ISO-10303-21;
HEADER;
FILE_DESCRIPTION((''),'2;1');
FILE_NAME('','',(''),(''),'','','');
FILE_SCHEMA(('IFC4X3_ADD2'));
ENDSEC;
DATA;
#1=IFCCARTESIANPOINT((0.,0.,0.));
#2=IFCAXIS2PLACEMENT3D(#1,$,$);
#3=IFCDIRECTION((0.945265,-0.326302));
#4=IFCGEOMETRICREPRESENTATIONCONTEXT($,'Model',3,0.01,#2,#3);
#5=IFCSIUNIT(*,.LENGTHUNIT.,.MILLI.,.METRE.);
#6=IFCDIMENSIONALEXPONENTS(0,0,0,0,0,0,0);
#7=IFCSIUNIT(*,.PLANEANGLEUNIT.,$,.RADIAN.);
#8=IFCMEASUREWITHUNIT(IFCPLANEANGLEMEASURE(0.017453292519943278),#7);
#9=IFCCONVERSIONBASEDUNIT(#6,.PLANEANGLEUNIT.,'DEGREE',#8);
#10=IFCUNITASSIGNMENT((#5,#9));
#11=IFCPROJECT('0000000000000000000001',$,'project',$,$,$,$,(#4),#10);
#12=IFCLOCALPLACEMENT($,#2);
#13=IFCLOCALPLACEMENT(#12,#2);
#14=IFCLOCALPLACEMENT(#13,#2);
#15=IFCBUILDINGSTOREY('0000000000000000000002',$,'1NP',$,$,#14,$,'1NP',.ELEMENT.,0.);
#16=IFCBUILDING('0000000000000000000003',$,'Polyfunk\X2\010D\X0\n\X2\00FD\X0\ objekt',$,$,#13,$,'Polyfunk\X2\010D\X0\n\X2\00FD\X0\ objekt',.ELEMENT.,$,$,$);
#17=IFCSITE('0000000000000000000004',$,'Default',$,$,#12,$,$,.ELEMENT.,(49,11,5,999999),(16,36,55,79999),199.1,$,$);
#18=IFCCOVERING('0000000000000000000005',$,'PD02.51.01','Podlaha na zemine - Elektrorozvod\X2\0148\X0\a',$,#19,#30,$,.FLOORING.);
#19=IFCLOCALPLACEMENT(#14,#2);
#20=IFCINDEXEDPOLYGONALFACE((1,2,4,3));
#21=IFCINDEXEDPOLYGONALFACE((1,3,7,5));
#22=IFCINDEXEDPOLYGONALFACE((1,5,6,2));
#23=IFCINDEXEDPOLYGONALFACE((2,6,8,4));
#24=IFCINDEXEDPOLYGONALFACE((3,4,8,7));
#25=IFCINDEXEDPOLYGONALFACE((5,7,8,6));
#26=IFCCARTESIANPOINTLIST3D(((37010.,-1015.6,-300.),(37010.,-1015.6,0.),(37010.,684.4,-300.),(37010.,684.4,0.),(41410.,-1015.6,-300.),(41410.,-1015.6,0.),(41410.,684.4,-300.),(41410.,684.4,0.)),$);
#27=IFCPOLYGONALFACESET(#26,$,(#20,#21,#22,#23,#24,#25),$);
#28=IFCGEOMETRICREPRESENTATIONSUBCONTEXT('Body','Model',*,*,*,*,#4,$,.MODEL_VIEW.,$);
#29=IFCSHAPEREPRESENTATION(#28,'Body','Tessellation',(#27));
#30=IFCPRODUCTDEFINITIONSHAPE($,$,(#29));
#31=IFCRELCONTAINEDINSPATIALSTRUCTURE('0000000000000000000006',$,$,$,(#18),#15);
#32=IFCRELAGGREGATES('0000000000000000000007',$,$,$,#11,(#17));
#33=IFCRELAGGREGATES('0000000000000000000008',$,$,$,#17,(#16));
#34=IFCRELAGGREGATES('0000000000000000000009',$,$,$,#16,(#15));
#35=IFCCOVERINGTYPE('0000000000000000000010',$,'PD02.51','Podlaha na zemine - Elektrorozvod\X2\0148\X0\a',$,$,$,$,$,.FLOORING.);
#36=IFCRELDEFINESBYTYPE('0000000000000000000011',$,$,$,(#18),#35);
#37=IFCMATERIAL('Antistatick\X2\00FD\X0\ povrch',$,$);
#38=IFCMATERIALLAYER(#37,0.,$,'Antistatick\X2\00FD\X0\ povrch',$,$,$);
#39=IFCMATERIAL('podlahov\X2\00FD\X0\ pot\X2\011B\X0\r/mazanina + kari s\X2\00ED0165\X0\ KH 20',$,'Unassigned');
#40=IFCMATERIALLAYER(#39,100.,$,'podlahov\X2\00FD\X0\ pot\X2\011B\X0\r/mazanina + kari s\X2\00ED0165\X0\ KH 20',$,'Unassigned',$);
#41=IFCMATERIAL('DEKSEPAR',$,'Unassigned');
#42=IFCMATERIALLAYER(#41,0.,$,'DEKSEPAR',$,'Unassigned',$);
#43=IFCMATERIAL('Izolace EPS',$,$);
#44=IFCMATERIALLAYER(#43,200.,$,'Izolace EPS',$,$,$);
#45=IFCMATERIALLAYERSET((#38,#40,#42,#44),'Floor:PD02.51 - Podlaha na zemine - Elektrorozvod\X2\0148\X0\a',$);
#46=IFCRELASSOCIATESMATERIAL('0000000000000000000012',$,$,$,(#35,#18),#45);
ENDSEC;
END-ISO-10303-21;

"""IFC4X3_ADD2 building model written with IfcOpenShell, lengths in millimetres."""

from ifc_helpers import new_model, entity, si_unit, converted_unit, direction, frame, frame_2d, origin, place, context, subcontext, project, spatial, rectangle, extrude, material, layer, layer_set, layer_usage, type_object, element, save


model = new_model("IFC4X3_ADD2")

# Units and contexts
model_context = context("Model", 3, precision=0.01, world=origin(), true_north=direction((0.945265, -0.326302)))
body_context = subcontext(model_context, "Body", "Model", "MODEL_VIEW")
ifc_project = project(units=[si_unit("LENGTHUNIT", "METRE", prefix="MILLI"), converted_unit("PLANEANGLEUNIT", "DEGREE", entity("IfcPlaneAngleMeasure", 0.017453292519943278), si_unit("PLANEANGLEUNIT", "RADIAN"), dimensions=[0, 0, 0, 0, 0, 0, 0])], contexts=[model_context])

# Site, building, storey
site_placement = place(None, origin())
site = spatial("IfcSite", under=ifc_project, at=site_placement, Name="Default", CompositionType="ELEMENT", RefLatitude=(49, 11, 5, 999999), RefLongitude=(16, 36, 55, 79999), RefElevation=199.1)
building_placement = place(site_placement, origin())
building = spatial("IfcBuilding", under=site, at=building_placement, Name="Polyfunkčný objekt", LongName="Polyfunkčný objekt", CompositionType="ELEMENT")
storey_placement = place(building_placement, origin())
storey = spatial("IfcBuildingStorey", under=building, at=storey_placement, Name="1NP", LongName="1NP", CompositionType="ELEMENT", Elevation=0.0)

# Shared definitions
ifc_material_1 = material(Name="podlahový potěr/mazanina + kari síť KH 20", Category="Unassigned")
ifc_material_2 = material(Name="DEKSEPAR", Category="Unassigned")
ifc_material_3 = material(Name="Izolace EPS")

# Covering
ifc_material_4 = material(Name="Antistatický povrch")
ifc_layer_1 = layer(ifc_material_4, 0.0, Name="Antistatický povrch")
ifc_layer_2 = layer(ifc_material_1, 100.0, Name="podlahový potěr/mazanina + kari síť KH 20", Category="Unassigned")
ifc_layer_3 = layer(ifc_material_2, 0.0, Name="DEKSEPAR", Category="Unassigned")
ifc_layer_4 = layer(ifc_material_3, 200.0, Name="Izolace EPS")
ifc_layer_set_1 = layer_set([ifc_layer_1, ifc_layer_2, ifc_layer_3, ifc_layer_4], Name="Floor:PD02.51 - Podlaha na zemine - Elektrorozvodňa")
ifc_layer_usage_1 = layer_usage(ifc_layer_set_1, "AXIS3", "POSITIVE", 0.0)
covering_type_1 = type_object("IfcCoveringType", Name="PD02.51", Description="Podlaha na zemine - Elektrorozvodňa", PredefinedType="FLOORING", material=ifc_layer_set_1)
covering_1_placement = place(storey_placement, origin())
element("IfcCovering", 1, at=covering_1_placement, inside=storey, type_object=covering_type_1, material=ifc_layer_usage_1, Name="PD02.51.01", Description="Podlaha na zemine - Elektrorozvodňa", PredefinedType="FLOORING", context=body_context, shape_type="SweptSolid", body=[
    extrude(rectangle(XDim=1700.0, YDim=4400.0, at=frame_2d((0.0, 0.0), x_axis=(1.0, 0.0))), frame((39210.0, -165.6, 0.0), z_axis=(0.0, 0.0, -1.0), x_axis=(0.0, 1.0, 0.0)), (0.0, 0.0, 1.0), 300.0),
])

save(model, "model.ifc")
